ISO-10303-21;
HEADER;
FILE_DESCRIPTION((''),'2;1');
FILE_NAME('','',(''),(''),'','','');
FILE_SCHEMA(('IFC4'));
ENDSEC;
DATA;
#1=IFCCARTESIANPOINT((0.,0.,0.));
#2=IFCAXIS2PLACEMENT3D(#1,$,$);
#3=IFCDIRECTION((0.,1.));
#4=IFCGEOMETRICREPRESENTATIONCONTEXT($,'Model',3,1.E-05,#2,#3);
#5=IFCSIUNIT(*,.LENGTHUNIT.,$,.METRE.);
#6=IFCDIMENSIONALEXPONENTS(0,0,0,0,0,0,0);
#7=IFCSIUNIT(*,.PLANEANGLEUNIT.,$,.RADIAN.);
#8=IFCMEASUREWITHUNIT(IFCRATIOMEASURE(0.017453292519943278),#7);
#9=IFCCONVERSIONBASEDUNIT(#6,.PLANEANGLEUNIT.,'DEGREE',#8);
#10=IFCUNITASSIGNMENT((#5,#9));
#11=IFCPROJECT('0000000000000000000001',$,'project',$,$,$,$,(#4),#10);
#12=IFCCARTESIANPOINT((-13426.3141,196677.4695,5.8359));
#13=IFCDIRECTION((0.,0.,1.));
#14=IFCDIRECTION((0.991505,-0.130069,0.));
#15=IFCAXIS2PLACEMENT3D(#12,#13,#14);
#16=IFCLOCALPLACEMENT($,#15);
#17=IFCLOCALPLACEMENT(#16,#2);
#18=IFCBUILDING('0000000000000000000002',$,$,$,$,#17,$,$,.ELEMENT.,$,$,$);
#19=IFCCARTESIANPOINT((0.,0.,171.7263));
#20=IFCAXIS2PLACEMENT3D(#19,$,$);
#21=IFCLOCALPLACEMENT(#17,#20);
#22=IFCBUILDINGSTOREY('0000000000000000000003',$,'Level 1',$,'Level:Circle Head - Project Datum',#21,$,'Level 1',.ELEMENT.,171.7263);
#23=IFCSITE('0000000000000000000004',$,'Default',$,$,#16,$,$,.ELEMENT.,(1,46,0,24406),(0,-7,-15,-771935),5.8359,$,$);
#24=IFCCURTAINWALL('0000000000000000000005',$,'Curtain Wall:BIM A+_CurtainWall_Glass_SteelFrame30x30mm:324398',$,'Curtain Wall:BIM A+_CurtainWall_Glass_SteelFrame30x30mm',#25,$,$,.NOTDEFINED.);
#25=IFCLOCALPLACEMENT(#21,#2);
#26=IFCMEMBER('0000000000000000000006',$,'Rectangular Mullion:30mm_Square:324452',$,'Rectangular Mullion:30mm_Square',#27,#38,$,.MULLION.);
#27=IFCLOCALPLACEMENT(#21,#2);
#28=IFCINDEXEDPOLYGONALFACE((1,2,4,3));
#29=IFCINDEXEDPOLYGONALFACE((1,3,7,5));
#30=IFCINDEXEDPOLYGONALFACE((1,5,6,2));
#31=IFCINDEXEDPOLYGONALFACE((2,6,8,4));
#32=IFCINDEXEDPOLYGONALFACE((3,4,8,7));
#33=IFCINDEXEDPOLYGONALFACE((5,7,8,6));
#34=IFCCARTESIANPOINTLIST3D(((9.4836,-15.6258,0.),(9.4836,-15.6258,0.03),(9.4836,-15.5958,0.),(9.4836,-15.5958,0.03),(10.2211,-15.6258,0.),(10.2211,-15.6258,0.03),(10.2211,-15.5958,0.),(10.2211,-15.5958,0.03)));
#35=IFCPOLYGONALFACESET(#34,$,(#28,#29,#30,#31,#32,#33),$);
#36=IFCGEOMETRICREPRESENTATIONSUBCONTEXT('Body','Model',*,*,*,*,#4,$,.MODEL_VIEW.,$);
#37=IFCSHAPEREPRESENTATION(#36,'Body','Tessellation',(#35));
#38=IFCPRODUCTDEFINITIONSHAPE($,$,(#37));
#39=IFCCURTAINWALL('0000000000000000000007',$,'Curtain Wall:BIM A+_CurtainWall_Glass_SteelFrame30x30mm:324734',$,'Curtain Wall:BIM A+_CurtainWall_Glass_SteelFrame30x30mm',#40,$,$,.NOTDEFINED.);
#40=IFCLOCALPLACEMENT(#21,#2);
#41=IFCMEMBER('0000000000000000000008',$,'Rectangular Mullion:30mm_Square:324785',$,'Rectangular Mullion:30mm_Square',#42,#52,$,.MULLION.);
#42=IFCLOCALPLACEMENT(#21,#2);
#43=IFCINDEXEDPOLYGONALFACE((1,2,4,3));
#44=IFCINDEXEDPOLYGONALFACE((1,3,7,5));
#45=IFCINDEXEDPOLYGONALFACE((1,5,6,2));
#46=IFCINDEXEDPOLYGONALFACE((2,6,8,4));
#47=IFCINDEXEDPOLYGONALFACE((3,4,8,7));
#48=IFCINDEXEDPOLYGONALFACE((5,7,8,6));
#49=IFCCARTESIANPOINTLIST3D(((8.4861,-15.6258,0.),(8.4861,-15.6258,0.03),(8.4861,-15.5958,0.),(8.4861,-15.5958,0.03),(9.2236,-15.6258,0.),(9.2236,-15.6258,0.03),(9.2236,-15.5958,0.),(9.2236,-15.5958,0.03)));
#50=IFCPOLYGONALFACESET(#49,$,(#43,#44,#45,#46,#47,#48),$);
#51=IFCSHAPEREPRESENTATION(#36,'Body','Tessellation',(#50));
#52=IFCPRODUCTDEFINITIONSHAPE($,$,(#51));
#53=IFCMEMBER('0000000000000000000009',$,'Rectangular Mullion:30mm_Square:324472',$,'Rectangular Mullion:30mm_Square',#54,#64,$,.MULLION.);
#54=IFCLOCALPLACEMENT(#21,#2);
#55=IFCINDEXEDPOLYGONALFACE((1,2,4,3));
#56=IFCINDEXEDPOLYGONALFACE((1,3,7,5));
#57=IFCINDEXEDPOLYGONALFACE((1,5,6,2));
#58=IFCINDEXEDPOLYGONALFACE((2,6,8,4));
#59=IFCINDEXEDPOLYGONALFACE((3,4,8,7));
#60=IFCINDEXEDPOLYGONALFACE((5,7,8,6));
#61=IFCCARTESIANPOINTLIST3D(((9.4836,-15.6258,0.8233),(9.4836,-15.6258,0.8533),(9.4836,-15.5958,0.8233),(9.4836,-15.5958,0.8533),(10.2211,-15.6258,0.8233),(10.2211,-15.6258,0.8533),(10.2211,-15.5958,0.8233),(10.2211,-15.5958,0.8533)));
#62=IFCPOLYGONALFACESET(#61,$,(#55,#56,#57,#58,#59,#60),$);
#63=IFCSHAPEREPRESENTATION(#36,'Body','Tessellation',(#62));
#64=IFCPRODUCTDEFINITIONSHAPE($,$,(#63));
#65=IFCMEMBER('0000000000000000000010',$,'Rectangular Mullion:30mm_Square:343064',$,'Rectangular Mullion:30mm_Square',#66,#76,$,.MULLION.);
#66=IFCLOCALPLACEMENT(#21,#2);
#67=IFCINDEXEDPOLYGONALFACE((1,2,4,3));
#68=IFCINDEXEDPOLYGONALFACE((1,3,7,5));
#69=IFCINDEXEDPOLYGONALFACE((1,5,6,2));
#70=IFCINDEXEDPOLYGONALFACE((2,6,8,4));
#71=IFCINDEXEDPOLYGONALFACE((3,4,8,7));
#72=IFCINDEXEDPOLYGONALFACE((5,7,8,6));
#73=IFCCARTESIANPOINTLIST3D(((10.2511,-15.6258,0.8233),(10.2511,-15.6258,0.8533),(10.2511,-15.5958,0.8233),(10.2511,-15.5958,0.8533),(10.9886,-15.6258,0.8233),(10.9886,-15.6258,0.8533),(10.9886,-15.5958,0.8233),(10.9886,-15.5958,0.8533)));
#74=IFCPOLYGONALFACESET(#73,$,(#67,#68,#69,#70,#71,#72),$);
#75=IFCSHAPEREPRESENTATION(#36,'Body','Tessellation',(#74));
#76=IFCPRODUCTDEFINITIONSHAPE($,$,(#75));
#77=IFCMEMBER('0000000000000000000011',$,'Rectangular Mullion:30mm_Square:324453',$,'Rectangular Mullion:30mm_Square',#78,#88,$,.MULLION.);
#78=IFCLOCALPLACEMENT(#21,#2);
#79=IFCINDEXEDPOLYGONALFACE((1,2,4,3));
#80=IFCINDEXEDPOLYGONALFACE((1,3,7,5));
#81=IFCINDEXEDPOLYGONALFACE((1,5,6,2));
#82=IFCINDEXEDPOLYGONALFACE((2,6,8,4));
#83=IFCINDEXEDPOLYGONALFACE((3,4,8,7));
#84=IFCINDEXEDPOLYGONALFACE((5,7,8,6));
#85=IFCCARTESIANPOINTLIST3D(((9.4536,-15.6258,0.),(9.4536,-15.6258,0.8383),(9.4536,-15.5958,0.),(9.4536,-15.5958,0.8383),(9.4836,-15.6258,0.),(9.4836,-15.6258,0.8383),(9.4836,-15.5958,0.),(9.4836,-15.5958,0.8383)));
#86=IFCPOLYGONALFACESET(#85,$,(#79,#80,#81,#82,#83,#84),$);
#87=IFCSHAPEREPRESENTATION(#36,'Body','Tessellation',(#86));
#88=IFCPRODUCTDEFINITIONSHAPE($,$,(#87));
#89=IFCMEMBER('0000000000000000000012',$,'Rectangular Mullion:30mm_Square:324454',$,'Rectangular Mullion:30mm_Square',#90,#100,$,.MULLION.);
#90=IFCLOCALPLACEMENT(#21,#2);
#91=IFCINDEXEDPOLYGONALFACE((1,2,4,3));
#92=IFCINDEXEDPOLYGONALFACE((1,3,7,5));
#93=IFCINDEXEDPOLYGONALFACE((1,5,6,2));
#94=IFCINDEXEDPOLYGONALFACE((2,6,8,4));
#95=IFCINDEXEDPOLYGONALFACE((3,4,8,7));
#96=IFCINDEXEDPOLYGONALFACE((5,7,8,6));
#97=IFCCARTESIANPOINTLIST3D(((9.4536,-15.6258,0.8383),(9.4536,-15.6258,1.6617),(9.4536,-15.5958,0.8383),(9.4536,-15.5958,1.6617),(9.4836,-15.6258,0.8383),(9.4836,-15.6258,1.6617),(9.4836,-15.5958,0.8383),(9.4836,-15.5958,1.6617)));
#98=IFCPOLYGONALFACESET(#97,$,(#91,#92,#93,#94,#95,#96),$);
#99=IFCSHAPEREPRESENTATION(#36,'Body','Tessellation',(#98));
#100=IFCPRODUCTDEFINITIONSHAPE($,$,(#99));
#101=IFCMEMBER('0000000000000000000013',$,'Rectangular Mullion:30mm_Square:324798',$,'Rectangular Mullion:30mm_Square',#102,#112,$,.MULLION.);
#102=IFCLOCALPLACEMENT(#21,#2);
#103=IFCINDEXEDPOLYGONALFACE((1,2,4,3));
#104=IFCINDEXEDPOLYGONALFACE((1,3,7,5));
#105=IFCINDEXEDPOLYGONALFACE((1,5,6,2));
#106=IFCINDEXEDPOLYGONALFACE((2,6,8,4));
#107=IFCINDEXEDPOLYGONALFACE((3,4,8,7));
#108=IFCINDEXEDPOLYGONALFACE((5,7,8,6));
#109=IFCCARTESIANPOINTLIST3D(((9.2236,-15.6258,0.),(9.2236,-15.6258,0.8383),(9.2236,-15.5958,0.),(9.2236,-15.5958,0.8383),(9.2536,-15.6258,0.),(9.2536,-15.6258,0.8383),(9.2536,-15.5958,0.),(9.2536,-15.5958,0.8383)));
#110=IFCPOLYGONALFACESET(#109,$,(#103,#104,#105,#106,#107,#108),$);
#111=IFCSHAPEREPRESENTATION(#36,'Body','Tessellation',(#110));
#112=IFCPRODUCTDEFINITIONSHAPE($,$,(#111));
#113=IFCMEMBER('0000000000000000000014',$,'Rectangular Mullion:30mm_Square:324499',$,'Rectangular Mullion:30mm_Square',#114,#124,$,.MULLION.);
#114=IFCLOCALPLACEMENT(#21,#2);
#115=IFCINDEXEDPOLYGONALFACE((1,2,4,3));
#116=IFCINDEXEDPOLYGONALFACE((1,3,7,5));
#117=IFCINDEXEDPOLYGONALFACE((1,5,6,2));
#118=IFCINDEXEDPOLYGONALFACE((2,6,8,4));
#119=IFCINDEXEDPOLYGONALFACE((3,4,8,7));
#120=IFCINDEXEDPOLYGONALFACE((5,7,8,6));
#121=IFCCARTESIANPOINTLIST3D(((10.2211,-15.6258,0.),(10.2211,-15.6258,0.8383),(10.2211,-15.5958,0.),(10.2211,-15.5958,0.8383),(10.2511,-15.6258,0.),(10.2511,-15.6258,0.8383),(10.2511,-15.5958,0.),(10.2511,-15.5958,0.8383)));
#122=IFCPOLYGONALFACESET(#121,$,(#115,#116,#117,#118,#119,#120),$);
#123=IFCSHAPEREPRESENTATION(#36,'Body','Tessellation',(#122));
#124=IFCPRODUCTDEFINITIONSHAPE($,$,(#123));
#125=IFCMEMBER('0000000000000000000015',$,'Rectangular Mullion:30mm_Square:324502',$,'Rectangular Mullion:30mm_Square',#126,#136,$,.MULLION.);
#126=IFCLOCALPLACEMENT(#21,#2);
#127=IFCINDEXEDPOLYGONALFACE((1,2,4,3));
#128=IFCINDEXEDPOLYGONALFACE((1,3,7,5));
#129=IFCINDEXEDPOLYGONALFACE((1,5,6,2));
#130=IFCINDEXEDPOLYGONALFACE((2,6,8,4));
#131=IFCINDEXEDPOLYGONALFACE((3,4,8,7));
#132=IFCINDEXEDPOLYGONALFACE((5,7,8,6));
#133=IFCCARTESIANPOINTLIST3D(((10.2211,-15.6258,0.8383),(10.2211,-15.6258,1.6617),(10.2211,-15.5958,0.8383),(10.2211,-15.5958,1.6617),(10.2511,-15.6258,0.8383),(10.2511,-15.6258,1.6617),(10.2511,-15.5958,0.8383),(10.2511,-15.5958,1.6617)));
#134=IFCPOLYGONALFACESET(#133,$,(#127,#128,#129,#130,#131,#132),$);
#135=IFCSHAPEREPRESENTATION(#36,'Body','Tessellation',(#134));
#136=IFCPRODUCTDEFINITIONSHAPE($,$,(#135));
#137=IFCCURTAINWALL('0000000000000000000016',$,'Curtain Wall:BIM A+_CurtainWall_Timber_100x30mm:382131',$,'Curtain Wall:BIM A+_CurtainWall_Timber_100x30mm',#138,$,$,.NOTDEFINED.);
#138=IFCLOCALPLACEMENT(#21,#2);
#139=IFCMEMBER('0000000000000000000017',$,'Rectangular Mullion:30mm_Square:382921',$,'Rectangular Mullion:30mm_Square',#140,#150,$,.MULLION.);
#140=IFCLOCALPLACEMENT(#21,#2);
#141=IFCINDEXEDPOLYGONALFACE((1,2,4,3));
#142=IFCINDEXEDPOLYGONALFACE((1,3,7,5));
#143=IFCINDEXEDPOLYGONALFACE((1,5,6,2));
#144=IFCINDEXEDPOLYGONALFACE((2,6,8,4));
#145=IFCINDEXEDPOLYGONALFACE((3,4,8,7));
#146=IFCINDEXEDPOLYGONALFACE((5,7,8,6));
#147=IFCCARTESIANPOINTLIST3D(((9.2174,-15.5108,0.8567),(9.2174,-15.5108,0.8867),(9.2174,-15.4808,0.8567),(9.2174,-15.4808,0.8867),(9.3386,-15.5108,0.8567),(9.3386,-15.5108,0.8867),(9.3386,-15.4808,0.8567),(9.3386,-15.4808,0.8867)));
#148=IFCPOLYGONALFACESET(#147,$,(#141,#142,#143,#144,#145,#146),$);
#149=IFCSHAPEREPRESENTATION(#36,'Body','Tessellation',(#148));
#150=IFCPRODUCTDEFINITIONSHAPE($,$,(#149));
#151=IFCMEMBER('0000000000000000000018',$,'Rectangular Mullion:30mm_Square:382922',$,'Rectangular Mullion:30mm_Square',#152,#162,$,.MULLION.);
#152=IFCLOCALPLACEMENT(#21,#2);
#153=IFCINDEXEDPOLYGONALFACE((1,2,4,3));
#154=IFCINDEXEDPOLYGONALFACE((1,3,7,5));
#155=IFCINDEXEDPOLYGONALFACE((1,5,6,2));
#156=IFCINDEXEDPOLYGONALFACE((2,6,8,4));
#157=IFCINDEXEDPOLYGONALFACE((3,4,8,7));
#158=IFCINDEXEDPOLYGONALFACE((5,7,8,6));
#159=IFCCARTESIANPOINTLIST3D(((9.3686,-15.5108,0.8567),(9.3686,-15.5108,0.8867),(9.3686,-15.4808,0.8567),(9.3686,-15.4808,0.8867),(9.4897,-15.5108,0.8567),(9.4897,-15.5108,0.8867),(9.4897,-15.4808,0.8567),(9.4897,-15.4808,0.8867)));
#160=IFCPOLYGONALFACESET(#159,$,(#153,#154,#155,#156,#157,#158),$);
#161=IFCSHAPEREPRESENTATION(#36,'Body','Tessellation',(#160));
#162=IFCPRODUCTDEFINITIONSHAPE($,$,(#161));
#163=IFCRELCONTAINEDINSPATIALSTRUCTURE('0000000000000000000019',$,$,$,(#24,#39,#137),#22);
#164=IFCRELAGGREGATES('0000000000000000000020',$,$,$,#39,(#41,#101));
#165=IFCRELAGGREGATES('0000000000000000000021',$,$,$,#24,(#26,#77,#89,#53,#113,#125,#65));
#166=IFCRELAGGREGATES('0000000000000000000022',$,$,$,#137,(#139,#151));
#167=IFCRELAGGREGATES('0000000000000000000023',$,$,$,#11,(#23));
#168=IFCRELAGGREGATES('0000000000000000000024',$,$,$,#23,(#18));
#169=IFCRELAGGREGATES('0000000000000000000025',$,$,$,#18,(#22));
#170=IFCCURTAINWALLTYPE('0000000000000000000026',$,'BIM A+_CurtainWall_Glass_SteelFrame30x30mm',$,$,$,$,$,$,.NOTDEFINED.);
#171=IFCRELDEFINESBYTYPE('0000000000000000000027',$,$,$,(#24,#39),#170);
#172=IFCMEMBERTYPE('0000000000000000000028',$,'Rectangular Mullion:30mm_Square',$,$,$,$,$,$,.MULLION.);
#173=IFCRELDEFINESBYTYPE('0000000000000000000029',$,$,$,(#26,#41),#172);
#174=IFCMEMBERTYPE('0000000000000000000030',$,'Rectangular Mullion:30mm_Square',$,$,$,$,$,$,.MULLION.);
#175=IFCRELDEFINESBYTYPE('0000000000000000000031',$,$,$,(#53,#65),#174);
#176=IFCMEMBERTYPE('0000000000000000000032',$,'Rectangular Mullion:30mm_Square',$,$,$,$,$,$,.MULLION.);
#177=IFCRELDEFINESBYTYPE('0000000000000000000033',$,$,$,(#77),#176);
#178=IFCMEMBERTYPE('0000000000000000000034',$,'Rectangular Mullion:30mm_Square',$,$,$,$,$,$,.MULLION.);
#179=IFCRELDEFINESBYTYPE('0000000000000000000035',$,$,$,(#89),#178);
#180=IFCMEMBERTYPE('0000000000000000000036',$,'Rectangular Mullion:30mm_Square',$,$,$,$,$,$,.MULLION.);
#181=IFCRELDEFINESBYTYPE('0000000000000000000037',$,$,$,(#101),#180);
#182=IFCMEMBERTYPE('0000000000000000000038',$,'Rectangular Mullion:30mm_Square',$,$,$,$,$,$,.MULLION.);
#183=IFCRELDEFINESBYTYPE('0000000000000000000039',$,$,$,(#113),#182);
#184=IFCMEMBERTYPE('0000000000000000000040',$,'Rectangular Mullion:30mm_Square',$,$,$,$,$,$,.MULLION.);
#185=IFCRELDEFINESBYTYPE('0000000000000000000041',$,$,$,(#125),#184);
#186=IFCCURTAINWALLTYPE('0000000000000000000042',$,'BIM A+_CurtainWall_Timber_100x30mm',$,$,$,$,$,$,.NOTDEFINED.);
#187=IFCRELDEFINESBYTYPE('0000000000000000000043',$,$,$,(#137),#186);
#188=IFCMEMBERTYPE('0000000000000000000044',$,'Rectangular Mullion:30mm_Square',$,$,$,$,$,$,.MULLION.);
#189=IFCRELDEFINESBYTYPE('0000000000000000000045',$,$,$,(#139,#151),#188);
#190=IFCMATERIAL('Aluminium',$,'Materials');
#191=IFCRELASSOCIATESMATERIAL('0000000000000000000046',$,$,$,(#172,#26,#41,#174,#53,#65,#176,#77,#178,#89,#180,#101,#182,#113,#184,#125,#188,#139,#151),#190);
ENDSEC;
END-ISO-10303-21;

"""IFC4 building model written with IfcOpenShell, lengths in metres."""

from ifc_helpers import new_model, entity, si_unit, converted_unit, direction, frame, origin, place, context, subcontext, project, spatial, indexed_curve, outline, extrude, source, transform, mapped, material, type_object, type_shapes, element, aggregate, save


model = new_model("IFC4")

# Units and contexts
model_context = context("Model", 3, precision=1e-05, world=origin(), true_north=direction((0.0, 1.0)))
body_context = subcontext(model_context, "Body", "Model", "MODEL_VIEW")
ifc_project = project(units=[si_unit("LENGTHUNIT", "METRE"), converted_unit("PLANEANGLEUNIT", "DEGREE", entity("IfcRatioMeasure", 0.017453292519943278), si_unit("PLANEANGLEUNIT", "RADIAN"), dimensions=[0, 0, 0, 0, 0, 0, 0])], contexts=[model_context])

# Site, building, storey
site_placement = place(None, frame((-13426.3141, 196677.4695, 5.8359), z_axis=(0.0, 0.0, 1.0), x_axis=(0.991505, -0.130069, 0.0)))
site = spatial("IfcSite", under=ifc_project, at=site_placement, Name="Default", CompositionType="ELEMENT", RefLatitude=(1, 46, 0, 24406), RefLongitude=(0, -7, -15, -771935), RefElevation=5.8359)
building_placement = place(site_placement, origin())
building = spatial("IfcBuilding", under=site, at=building_placement, CompositionType="ELEMENT")
storey_placement = place(building_placement, frame((0.0, 0.0, 171.7263)))
storey = spatial("IfcBuildingStorey", under=building, at=storey_placement, Name="Level 1", ObjectType="Level:Circle Head - Project Datum", LongName="Level 1", CompositionType="ELEMENT", Elevation=171.7263)

# Curtain walls, members
curtain_wall_type_1 = type_object("IfcCurtainWallType", Name="BIM A+_CurtainWall_Glass_SteelFrame30x30mm", PredefinedType="NOTDEFINED")
curtain_wall_1_placement = place(storey_placement, frame((0.0, 0.0, -171.7263)))
curtain_wall_1 = element("IfcCurtainWall", 1, at=curtain_wall_1_placement, inside=storey, type_object=curtain_wall_type_1, Name="Curtain Wall:BIM A+_CurtainWall_Glass_SteelFrame30x30mm:324398", ObjectType="Curtain Wall:BIM A+_CurtainWall_Glass_SteelFrame30x30mm", PredefinedType="NOTDEFINED")
ifc_material_1 = material(Name="Aluminium", Category="Materials")
member_type_1 = type_object("IfcMemberType", Name="Rectangular Mullion:30mm_Square", PredefinedType="MULLION", material=ifc_material_1)
shared_shape_1 = source(origin(), body_context, "Body", "SweptSolid", [
    extrude(outline(indexed_curve([(-0.015, -0.015), (0.015, -0.015), (0.015, 0.015), (-0.015, 0.015), (-0.015, -0.015)], self_intersect=False)), frame((-0.015, 0.0, -0.7375), z_axis=(0.0, 0.0, 1.0), x_axis=(0.0, -1.0, 0.0)), (0.0, 0.0, 1.0), 0.7375),
])
type_shapes(member_type_1, [shared_shape_1])
member_1_placement = place(curtain_wall_1_placement, frame((10.2211, -15.6108, 171.7263), z_axis=(1.0, 0.0, 0.0), x_axis=(0.0, 0.0, -1.0)))
member_1 = element("IfcMember", 2, at=member_1_placement, type_object=member_type_1, material=ifc_material_1, Name="Rectangular Mullion:30mm_Square:324452", ObjectType="Rectangular Mullion:30mm_Square", PredefinedType="MULLION", context=body_context, shape_type="MappedRepresentation", body=[
    mapped(shared_shape_1, transform((0.0, 0.0, 0.0), scale=1.0)),
])
curtain_wall_2_placement = place(storey_placement, frame((0.0, 0.0, -171.7263)))
curtain_wall_2 = element("IfcCurtainWall", 3, at=curtain_wall_2_placement, inside=storey, type_object=curtain_wall_type_1, Name="Curtain Wall:BIM A+_CurtainWall_Glass_SteelFrame30x30mm:324734", ObjectType="Curtain Wall:BIM A+_CurtainWall_Glass_SteelFrame30x30mm", PredefinedType="NOTDEFINED")
member_2_placement = place(curtain_wall_2_placement, frame((9.2236, -15.6108, 171.7263), z_axis=(1.0, 0.0, 0.0), x_axis=(0.0, 0.0, -1.0)))
member_2 = element("IfcMember", 4, at=member_2_placement, type_object=member_type_1, material=ifc_material_1, Name="Rectangular Mullion:30mm_Square:324785", ObjectType="Rectangular Mullion:30mm_Square", PredefinedType="MULLION", context=body_context, shape_type="MappedRepresentation", body=[
    mapped(shared_shape_1, transform((0.0, 0.0, 0.0), scale=1.0)),
])

# Members
member_type_2 = type_object("IfcMemberType", Name="Rectangular Mullion:30mm_Square", PredefinedType="MULLION", material=ifc_material_1)
shared_shape_2 = source(origin(), body_context, "Body", "SweptSolid", [
    extrude(outline(indexed_curve([(-0.015, -0.015), (0.015, -0.015), (0.015, 0.015), (-0.015, 0.015), (-0.015, -0.015)], self_intersect=False)), frame((0.0, 0.0, -0.7375), z_axis=(0.0, 0.0, 1.0), x_axis=(0.0, -1.0, 0.0)), (0.0, 0.0, 1.0), 0.7375),
])
type_shapes(member_type_2, [shared_shape_2])
member_3_placement = place(curtain_wall_1_placement, frame((9.4836, -15.6108, 172.5646), z_axis=(-1.0, 0.0, 0.0), x_axis=(0.0, 0.0, 1.0)))
member_3 = element("IfcMember", 5, at=member_3_placement, type_object=member_type_2, material=ifc_material_1, Name="Rectangular Mullion:30mm_Square:324472", ObjectType="Rectangular Mullion:30mm_Square", PredefinedType="MULLION", context=body_context, shape_type="MappedRepresentation", body=[
    mapped(shared_shape_2, transform((0.0, 0.0, 0.0), scale=1.0)),
])
member_4_placement = place(curtain_wall_1_placement, frame((10.2511, -15.6108, 172.5646), z_axis=(-1.0, 0.0, 0.0), x_axis=(0.0, 0.0, 1.0)))
member_4 = element("IfcMember", 6, at=member_4_placement, type_object=member_type_2, material=ifc_material_1, Name="Rectangular Mullion:30mm_Square:343064", ObjectType="Rectangular Mullion:30mm_Square", PredefinedType="MULLION", context=body_context, shape_type="MappedRepresentation", body=[
    mapped(shared_shape_2, transform((0.0, 0.0, 0.0), scale=1.0)),
])
member_type_3 = type_object("IfcMemberType", Name="Rectangular Mullion:30mm_Square", PredefinedType="MULLION", material=ifc_material_1)
shared_shape_3 = source(origin(), body_context, "Body", "SweptSolid", [
    extrude(outline(indexed_curve([(-0.015, -0.015), (0.015, -0.015), (0.015, 0.015), (-0.015, 0.015), (-0.015, -0.015)], self_intersect=False)), frame((-0.015, 0.0, -0.8383), z_axis=(0.0, 0.0, 1.0), x_axis=(0.0, -1.0, 0.0)), (0.0, 0.0, 1.0), 0.8383),
])
type_shapes(member_type_3, [shared_shape_3])
member_5_placement = place(curtain_wall_1_placement, frame((9.4536, -15.6108, 171.7263), z_axis=(0.0, 0.0, -1.0), x_axis=(-1.0, 0.0, 0.0)))
member_5 = element("IfcMember", 7, at=member_5_placement, type_object=member_type_3, material=ifc_material_1, Name="Rectangular Mullion:30mm_Square:324453", ObjectType="Rectangular Mullion:30mm_Square", PredefinedType="MULLION", context=body_context, shape_type="MappedRepresentation", body=[
    mapped(shared_shape_3, transform((0.0, 0.0, 0.0), scale=1.0)),
])
member_type_4 = type_object("IfcMemberType", Name="Rectangular Mullion:30mm_Square", PredefinedType="MULLION", material=ifc_material_1)
shared_shape_4 = source(origin(), body_context, "Body", "SweptSolid", [
    extrude(outline(indexed_curve([(-0.015, -0.015), (0.015, -0.015), (0.015, 0.015), (-0.015, 0.015), (-0.015, -0.015)], self_intersect=False)), frame((-0.015, 0.0, -0.8233), z_axis=(0.0, 0.0, 1.0), x_axis=(0.0, -1.0, 0.0)), (0.0, 0.0, 1.0), 0.8233),
])
type_shapes(member_type_4, [shared_shape_4])
member_6_placement = place(curtain_wall_1_placement, frame((9.4536, -15.6108, 172.5646), z_axis=(0.0, 0.0, -1.0), x_axis=(-1.0, 0.0, 0.0)))
member_6 = element("IfcMember", 8, at=member_6_placement, type_object=member_type_4, material=ifc_material_1, Name="Rectangular Mullion:30mm_Square:324454", ObjectType="Rectangular Mullion:30mm_Square", PredefinedType="MULLION", context=body_context, shape_type="MappedRepresentation", body=[
    mapped(shared_shape_4, transform((0.0, 0.0, 0.0), scale=1.0)),
])
member_type_5 = type_object("IfcMemberType", Name="Rectangular Mullion:30mm_Square", PredefinedType="MULLION", material=ifc_material_1)
shared_shape_5 = source(origin(), body_context, "Body", "SweptSolid", [
    extrude(outline(indexed_curve([(-0.015, -0.015), (0.015, -0.015), (0.015, 0.015), (-0.015, 0.015), (-0.015, -0.015)], self_intersect=False)), frame((-0.015, 0.0, -0.8383), z_axis=(0.0, 0.0, 1.0), x_axis=(0.0, -1.0, 0.0)), (0.0, 0.0, 1.0), 0.8383),
])
type_shapes(member_type_5, [shared_shape_5])
member_7_placement = place(curtain_wall_2_placement, frame((9.2536, -15.6108, 172.5646)))
member_7 = element("IfcMember", 9, at=member_7_placement, type_object=member_type_5, material=ifc_material_1, Name="Rectangular Mullion:30mm_Square:324798", ObjectType="Rectangular Mullion:30mm_Square", PredefinedType="MULLION", context=body_context, shape_type="MappedRepresentation", body=[
    mapped(shared_shape_5, transform((0.0, 0.0, 0.0), scale=1.0)),
])
aggregate(curtain_wall_2, [member_2, member_7])
member_type_6 = type_object("IfcMemberType", Name="Rectangular Mullion:30mm_Square", PredefinedType="MULLION", material=ifc_material_1)
shared_shape_6 = source(origin(), body_context, "Body", "SweptSolid", [
    extrude(outline(indexed_curve([(-0.015, -0.015), (0.015, -0.015), (0.015, 0.015), (-0.015, 0.015), (-0.015, -0.015)], self_intersect=False)), frame((0.0, 0.0, -0.8383), z_axis=(0.0, 0.0, 1.0), x_axis=(0.0, -1.0, 0.0)), (0.0, 0.0, 1.0), 0.8383),
])
type_shapes(member_type_6, [shared_shape_6])
member_8_placement = place(curtain_wall_1_placement, frame((10.2361, -15.6108, 171.7263), z_axis=(0.0, 0.0, -1.0), x_axis=(-1.0, 0.0, 0.0)))
member_8 = element("IfcMember", 10, at=member_8_placement, type_object=member_type_6, material=ifc_material_1, Name="Rectangular Mullion:30mm_Square:324499", ObjectType="Rectangular Mullion:30mm_Square", PredefinedType="MULLION", context=body_context, shape_type="MappedRepresentation", body=[
    mapped(shared_shape_6, transform((0.0, 0.0, 0.0), scale=1.0)),
])
member_type_7 = type_object("IfcMemberType", Name="Rectangular Mullion:30mm_Square", PredefinedType="MULLION", material=ifc_material_1)
shared_shape_7 = source(origin(), body_context, "Body", "SweptSolid", [
    extrude(outline(indexed_curve([(-0.015, -0.015), (0.015, -0.015), (0.015, 0.015), (-0.015, 0.015), (-0.015, -0.015)], self_intersect=False)), frame((0.0, 0.0, -0.8233), z_axis=(0.0, 0.0, 1.0), x_axis=(0.0, -1.0, 0.0)), (0.0, 0.0, 1.0), 0.8233),
])
type_shapes(member_type_7, [shared_shape_7])
member_9_placement = place(curtain_wall_1_placement, frame((10.2361, -15.6108, 172.5646), z_axis=(0.0, 0.0, -1.0), x_axis=(-1.0, 0.0, 0.0)))
member_9 = element("IfcMember", 11, at=member_9_placement, type_object=member_type_7, material=ifc_material_1, Name="Rectangular Mullion:30mm_Square:324502", ObjectType="Rectangular Mullion:30mm_Square", PredefinedType="MULLION", context=body_context, shape_type="MappedRepresentation", body=[
    mapped(shared_shape_7, transform((0.0, 0.0, 0.0), scale=1.0)),
])

# Curtain wall, members
curtain_wall_type_2 = type_object("IfcCurtainWallType", Name="BIM A+_CurtainWall_Timber_100x30mm", PredefinedType="NOTDEFINED")
curtain_wall_3_placement = place(storey_placement, frame((0.0, 0.0, -171.7263)))
curtain_wall_3 = element("IfcCurtainWall", 12, at=curtain_wall_3_placement, inside=storey, type_object=curtain_wall_type_2, Name="Curtain Wall:BIM A+_CurtainWall_Timber_100x30mm:382131", ObjectType="Curtain Wall:BIM A+_CurtainWall_Timber_100x30mm", PredefinedType="NOTDEFINED")
member_type_8 = type_object("IfcMemberType", Name="Rectangular Mullion:30mm_Square", PredefinedType="MULLION", material=ifc_material_1)
shared_shape_8 = source(origin(), body_context, "Body", "SweptSolid", [
    extrude(outline(indexed_curve([(-0.015, -0.015), (0.015, -0.015), (0.015, 0.015), (-0.015, 0.015), (-0.015, -0.015)], self_intersect=False)), frame((0.0, 0.0, -0.1212), z_axis=(0.0, 0.0, 1.0), x_axis=(0.0, -1.0, 0.0)), (0.0, 0.0, 1.0), 0.1212),
])
type_shapes(member_type_8, [shared_shape_8])
member_10_placement = place(curtain_wall_3_placement, frame((9.3386, -15.4958, 172.598), z_axis=(1.0, 0.0, 0.0), x_axis=(0.0, 0.0, 1.0)))
member_10 = element("IfcMember", 13, at=member_10_placement, type_object=member_type_8, material=ifc_material_1, Name="Rectangular Mullion:30mm_Square:382921", ObjectType="Rectangular Mullion:30mm_Square", PredefinedType="MULLION", context=body_context, shape_type="MappedRepresentation", body=[
    mapped(shared_shape_8, transform((0.0, 0.0, 0.0), scale=1.0)),
])
member_11_placement = place(curtain_wall_3_placement, frame((9.4897, -15.4958, 172.598), z_axis=(1.0, 0.0, 0.0), x_axis=(0.0, 0.0, 1.0)))
member_11 = element("IfcMember", 14, at=member_11_placement, type_object=member_type_8, material=ifc_material_1, Name="Rectangular Mullion:30mm_Square:382922", ObjectType="Rectangular Mullion:30mm_Square", PredefinedType="MULLION", context=body_context, shape_type="MappedRepresentation", body=[
    mapped(shared_shape_8, transform((0.0, 0.0, 0.0), scale=1.0)),
])

aggregate(curtain_wall_1, [member_1, member_5, member_6, member_3, member_8, member_9, member_4])
aggregate(curtain_wall_3, [member_10, member_11])

save(model, "model.ifc")
